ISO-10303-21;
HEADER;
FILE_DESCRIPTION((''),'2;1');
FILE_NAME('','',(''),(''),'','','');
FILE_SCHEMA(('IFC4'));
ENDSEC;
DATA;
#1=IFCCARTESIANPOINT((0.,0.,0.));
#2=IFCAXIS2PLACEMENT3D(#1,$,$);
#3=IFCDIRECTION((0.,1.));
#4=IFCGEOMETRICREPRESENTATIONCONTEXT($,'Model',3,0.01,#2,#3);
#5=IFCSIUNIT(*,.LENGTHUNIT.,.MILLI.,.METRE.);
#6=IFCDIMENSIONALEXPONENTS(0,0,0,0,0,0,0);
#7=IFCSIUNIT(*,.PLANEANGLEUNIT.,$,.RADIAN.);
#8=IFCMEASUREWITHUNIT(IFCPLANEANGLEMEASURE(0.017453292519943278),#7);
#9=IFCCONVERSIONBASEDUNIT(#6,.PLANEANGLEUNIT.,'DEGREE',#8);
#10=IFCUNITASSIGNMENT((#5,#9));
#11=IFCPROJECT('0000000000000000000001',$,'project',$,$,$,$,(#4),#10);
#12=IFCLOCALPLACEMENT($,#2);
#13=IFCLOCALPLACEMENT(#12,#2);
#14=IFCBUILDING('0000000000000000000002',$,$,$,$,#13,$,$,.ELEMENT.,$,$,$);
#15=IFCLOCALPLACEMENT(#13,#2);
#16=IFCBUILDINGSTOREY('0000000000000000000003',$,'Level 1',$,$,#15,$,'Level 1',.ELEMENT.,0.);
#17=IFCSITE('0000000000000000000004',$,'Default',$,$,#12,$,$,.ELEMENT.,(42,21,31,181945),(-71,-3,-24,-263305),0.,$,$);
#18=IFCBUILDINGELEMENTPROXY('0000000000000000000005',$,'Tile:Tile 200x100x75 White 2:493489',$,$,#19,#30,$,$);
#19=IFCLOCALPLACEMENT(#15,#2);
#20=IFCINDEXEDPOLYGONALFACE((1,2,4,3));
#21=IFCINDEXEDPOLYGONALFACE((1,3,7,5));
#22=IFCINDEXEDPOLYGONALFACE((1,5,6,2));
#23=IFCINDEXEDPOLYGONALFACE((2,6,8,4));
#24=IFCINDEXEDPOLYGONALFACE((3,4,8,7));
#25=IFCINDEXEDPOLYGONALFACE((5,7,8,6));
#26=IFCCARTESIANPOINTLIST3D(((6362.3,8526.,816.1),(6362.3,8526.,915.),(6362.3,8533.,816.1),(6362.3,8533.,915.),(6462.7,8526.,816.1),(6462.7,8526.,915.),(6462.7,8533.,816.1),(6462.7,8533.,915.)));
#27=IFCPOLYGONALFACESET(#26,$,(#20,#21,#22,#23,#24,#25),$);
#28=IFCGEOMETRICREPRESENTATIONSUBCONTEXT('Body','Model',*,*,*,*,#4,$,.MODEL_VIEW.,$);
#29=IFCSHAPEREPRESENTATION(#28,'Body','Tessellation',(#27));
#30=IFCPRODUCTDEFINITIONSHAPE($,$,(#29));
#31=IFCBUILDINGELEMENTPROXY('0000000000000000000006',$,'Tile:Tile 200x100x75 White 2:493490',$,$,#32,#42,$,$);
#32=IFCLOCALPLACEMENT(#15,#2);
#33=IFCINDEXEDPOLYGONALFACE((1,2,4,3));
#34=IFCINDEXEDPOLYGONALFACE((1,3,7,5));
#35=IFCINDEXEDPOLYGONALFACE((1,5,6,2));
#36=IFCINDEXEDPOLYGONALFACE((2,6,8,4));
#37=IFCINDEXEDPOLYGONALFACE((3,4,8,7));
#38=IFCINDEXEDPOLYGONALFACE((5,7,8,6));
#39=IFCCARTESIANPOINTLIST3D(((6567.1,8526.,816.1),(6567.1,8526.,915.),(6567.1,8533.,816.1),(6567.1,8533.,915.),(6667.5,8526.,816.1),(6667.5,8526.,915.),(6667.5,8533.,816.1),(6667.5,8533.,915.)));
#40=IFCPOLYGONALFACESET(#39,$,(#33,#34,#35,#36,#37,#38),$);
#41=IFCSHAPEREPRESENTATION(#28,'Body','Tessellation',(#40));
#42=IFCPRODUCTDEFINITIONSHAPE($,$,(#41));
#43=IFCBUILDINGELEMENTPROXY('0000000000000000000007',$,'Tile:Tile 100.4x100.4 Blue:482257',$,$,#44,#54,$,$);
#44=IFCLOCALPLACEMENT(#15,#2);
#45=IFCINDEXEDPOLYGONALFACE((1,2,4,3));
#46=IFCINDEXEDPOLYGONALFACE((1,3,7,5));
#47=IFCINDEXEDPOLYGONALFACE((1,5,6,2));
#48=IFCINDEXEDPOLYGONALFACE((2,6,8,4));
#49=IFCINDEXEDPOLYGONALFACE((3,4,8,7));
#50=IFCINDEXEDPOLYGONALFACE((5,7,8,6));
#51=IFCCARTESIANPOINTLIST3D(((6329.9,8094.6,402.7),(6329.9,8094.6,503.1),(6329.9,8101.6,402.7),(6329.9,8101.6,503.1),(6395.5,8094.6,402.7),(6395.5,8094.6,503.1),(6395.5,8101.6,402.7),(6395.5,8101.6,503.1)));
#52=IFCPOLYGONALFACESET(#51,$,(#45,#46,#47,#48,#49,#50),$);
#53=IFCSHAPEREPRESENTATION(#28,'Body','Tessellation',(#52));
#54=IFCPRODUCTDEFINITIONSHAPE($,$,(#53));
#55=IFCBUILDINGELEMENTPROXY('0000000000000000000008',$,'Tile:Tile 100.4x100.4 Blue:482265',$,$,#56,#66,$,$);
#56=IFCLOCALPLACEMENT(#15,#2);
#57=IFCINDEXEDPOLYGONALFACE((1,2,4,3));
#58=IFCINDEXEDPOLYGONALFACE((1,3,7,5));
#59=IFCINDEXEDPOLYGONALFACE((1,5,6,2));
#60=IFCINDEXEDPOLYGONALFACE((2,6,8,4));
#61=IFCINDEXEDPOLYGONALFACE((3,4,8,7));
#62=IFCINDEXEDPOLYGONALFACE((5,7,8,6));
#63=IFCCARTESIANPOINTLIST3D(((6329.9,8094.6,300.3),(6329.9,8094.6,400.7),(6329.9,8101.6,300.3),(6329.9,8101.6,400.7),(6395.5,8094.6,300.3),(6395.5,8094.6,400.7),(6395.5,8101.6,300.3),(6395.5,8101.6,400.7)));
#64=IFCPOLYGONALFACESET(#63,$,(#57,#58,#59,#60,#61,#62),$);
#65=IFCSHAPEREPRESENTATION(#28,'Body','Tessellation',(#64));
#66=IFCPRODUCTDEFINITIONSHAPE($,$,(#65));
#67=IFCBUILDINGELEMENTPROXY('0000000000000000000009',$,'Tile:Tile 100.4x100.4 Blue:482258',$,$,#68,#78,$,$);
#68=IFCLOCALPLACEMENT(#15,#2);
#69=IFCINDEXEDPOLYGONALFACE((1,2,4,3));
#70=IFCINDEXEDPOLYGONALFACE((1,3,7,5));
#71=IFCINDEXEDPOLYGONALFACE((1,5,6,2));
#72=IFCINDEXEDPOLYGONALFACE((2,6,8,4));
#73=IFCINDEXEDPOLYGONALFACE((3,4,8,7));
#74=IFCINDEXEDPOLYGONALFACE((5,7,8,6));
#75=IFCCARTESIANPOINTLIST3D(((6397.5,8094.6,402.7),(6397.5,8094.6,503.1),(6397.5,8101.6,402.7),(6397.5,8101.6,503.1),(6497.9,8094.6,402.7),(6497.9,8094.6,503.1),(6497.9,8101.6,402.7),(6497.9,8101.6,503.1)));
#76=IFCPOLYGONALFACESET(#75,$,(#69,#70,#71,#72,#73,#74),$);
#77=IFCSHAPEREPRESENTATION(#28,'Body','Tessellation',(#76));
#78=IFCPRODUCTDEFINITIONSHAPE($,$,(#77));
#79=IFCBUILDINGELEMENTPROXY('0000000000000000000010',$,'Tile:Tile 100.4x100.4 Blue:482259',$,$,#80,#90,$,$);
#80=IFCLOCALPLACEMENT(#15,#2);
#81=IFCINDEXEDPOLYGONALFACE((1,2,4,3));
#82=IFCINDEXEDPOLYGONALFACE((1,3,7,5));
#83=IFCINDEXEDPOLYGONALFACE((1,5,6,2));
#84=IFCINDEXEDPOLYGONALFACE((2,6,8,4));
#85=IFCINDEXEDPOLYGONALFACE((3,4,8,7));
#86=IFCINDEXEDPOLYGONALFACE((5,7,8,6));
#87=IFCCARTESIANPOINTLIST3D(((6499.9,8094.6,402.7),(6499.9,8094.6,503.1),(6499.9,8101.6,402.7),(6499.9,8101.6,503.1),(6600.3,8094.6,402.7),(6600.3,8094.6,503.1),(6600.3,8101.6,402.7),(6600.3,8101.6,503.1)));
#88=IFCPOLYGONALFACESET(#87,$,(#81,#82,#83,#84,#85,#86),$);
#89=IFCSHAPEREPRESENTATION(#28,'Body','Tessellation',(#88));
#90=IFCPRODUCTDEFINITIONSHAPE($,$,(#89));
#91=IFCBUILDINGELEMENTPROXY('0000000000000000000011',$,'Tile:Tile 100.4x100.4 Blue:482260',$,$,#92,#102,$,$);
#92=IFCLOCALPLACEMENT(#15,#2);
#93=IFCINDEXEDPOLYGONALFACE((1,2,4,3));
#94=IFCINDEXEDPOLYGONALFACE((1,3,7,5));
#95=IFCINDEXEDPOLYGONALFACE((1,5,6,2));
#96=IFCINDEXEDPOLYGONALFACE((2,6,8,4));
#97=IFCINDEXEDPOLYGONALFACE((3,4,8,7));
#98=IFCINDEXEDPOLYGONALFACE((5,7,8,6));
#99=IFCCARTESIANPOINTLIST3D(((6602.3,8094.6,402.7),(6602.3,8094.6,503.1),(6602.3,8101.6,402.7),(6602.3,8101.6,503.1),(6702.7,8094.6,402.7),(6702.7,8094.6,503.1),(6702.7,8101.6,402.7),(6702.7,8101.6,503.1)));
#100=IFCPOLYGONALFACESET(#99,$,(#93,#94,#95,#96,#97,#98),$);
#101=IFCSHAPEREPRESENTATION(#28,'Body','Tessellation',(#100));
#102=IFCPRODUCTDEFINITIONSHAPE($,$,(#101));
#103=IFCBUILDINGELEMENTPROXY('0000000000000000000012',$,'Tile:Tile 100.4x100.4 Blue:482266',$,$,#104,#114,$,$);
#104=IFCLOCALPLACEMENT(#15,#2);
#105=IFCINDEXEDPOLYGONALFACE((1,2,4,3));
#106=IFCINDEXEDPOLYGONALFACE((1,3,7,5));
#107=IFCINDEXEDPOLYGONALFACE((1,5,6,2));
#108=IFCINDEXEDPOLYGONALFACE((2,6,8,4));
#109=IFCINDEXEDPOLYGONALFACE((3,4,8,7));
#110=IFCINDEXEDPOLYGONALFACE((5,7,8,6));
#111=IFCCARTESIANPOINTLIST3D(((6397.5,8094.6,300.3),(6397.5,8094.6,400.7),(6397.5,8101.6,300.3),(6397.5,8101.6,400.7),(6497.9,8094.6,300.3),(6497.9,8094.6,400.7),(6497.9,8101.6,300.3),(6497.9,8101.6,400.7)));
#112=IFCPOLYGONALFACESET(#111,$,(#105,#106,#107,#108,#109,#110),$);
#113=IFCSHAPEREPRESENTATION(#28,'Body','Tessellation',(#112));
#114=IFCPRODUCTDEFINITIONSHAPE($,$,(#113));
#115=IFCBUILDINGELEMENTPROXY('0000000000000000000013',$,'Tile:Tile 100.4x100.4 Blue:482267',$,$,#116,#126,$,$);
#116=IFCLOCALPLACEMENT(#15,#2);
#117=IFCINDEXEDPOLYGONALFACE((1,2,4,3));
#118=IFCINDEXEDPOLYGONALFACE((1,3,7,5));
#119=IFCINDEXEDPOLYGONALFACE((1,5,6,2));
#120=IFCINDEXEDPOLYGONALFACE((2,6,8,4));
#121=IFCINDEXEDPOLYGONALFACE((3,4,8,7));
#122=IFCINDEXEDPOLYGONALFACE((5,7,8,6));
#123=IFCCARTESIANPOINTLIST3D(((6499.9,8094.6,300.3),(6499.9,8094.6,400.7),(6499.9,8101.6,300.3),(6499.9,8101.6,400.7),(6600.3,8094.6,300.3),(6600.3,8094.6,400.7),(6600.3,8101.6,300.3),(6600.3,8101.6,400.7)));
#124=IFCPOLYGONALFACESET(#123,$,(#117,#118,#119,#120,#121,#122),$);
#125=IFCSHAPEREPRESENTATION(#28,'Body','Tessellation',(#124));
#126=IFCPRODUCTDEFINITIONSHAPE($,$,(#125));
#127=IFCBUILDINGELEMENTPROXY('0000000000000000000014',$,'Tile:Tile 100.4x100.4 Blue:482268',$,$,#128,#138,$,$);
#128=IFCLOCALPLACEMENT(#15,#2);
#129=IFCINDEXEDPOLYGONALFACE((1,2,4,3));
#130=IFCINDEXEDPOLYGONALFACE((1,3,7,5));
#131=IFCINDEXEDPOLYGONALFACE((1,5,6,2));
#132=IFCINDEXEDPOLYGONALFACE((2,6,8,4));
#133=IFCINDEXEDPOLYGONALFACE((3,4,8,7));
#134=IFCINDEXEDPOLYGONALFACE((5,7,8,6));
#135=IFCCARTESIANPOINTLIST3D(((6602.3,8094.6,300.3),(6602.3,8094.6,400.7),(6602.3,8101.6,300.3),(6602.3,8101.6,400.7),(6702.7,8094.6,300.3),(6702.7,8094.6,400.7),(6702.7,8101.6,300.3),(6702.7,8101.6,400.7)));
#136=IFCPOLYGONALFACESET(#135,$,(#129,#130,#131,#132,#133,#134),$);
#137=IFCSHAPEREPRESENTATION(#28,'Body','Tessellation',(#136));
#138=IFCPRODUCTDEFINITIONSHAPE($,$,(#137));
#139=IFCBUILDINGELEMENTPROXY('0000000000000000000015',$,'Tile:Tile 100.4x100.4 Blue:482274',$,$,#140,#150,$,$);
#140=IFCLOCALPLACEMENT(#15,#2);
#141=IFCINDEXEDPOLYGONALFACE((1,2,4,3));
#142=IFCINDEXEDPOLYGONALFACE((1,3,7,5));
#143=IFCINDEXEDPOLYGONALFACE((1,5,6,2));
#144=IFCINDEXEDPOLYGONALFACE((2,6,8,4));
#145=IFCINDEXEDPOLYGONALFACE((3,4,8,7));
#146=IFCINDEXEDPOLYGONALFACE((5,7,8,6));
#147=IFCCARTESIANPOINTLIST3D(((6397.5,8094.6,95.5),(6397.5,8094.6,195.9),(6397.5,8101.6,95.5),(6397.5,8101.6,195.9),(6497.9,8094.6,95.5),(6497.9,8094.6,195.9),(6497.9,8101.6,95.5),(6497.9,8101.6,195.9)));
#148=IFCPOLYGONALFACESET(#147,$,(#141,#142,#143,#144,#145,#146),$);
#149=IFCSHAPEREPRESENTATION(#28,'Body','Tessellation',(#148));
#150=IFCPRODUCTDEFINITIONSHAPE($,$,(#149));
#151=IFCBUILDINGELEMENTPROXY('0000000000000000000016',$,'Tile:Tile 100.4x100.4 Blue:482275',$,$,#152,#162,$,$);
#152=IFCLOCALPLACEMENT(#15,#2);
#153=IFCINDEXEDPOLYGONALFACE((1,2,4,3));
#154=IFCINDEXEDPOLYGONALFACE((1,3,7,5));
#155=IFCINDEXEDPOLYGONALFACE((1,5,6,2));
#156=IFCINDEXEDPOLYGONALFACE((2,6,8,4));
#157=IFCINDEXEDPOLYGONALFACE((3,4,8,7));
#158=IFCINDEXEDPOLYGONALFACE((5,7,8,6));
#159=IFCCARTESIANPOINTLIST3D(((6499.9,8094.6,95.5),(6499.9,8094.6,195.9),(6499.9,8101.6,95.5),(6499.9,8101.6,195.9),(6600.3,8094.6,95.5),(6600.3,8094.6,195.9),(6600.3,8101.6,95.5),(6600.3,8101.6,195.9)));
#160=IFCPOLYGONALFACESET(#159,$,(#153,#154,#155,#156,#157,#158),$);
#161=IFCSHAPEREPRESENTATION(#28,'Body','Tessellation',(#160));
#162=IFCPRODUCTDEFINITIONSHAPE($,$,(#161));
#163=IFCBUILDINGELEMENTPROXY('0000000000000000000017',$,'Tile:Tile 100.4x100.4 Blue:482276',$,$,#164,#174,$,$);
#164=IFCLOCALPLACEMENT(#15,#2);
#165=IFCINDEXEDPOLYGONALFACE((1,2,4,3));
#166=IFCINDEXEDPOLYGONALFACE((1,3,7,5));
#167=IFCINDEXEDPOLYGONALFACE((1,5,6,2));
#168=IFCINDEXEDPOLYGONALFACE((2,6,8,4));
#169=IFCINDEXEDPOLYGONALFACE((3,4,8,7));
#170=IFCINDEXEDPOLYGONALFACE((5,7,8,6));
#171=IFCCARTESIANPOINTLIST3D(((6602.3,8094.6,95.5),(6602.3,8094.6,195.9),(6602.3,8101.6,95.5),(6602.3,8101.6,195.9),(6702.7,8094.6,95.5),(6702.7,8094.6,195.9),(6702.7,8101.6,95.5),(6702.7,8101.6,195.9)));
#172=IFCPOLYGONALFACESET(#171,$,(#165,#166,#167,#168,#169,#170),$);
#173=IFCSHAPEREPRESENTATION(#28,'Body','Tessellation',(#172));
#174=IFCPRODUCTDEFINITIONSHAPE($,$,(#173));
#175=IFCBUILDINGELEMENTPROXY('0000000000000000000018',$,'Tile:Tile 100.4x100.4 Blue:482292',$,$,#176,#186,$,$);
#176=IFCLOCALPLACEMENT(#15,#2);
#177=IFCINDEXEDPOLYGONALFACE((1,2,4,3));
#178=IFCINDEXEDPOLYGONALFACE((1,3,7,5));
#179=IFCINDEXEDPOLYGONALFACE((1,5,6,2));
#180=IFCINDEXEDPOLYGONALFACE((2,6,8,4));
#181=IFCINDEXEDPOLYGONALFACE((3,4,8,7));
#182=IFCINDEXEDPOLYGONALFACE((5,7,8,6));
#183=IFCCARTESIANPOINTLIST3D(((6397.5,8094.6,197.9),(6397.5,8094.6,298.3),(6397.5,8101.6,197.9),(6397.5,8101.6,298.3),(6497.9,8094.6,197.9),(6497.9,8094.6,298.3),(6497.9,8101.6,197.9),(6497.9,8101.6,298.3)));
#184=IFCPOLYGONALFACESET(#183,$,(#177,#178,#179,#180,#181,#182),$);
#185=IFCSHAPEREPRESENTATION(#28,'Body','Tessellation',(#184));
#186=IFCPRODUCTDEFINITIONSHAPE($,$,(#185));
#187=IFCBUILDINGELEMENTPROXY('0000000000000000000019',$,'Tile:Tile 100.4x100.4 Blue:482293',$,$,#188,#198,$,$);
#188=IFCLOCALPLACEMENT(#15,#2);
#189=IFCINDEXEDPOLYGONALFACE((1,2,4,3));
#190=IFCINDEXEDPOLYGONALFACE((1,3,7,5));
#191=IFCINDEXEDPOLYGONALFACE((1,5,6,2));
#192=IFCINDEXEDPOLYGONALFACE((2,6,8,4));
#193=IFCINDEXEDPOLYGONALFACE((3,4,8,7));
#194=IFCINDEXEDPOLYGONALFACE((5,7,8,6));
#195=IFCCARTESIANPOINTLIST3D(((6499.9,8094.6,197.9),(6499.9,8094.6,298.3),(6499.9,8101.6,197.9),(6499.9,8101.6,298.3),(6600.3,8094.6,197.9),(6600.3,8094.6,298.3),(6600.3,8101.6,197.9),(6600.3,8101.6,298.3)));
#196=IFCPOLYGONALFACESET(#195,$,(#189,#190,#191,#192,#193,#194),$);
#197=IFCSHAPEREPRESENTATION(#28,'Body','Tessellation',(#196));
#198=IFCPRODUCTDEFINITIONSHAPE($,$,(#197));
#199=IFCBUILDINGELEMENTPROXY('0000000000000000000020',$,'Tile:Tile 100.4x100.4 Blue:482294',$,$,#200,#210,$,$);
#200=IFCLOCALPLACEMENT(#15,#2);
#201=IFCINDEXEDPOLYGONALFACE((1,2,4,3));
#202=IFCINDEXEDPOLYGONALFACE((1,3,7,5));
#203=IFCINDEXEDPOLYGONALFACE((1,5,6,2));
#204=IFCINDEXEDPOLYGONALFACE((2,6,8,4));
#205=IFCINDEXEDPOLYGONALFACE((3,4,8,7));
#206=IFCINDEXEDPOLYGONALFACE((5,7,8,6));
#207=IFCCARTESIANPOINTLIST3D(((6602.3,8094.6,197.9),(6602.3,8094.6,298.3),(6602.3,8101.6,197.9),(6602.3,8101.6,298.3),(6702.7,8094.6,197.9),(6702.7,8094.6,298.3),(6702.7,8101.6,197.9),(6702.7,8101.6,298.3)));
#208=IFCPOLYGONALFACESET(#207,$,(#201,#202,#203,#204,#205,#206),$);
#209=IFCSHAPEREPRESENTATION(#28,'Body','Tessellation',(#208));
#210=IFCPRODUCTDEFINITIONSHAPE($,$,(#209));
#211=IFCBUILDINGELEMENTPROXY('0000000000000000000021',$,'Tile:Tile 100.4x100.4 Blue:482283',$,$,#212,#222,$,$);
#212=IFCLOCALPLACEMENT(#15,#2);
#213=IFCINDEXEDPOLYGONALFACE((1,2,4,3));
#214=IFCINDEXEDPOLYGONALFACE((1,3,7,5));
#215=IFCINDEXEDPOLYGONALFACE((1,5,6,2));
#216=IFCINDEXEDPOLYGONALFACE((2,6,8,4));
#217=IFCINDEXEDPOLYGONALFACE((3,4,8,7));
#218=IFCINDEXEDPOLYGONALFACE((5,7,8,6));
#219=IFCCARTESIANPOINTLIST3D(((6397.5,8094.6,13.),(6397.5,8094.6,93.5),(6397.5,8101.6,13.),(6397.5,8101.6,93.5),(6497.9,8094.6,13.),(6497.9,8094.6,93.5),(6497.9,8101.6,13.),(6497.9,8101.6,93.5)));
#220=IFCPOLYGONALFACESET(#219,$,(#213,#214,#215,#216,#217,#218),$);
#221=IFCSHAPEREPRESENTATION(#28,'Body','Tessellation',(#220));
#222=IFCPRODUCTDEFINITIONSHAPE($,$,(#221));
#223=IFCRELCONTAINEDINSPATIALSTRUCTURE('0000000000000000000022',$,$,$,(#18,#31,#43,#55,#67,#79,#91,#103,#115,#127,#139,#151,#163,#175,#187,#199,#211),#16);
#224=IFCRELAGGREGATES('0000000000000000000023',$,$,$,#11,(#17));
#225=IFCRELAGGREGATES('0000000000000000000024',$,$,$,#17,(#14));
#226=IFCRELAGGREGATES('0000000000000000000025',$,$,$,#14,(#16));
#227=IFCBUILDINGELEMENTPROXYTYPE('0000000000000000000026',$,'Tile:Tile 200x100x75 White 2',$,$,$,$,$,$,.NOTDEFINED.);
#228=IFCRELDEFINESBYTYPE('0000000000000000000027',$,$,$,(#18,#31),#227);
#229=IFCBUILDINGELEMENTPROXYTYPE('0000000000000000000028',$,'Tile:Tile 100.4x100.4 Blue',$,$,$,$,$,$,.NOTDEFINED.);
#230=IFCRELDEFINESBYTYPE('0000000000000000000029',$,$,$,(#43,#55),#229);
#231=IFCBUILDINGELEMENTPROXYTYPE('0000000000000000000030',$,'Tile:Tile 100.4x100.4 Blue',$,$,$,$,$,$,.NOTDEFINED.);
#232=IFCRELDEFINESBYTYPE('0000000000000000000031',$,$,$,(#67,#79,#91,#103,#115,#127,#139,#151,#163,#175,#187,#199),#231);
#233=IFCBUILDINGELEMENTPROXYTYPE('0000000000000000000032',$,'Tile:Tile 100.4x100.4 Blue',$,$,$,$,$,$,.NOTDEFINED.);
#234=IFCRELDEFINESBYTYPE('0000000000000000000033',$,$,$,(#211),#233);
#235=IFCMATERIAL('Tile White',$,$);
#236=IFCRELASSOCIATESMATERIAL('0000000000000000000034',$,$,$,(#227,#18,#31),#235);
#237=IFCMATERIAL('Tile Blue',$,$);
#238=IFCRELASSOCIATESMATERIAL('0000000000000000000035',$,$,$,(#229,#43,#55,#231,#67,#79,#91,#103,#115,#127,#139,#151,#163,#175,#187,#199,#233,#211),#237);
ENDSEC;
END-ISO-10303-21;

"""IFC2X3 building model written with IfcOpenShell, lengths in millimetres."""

from ifc_helpers import new_model, entity, si_unit, converted_unit, direction, frame, frame_2d, origin, origin_2d_with_axis, place, context, subcontext, project, spatial, rectangle, extrude, source, transform, mapped, material, type_object, type_shapes, element, save


model = new_model("IFC2X3")

# Units and contexts
model_context = context("Model", 3, precision=0.01, world=origin(), true_north=direction((0.0, 1.0)))
body_context = subcontext(model_context, "Body", "Model", "MODEL_VIEW")
ifc_project = project(units=[si_unit("LENGTHUNIT", "METRE", prefix="MILLI"), converted_unit("PLANEANGLEUNIT", "DEGREE", entity("IfcPlaneAngleMeasure", 0.017453292519943278), si_unit("PLANEANGLEUNIT", "RADIAN"), dimensions=[0, 0, 0, 0, 0, 0, 0])], contexts=[model_context])

# Site, building, storey
site_placement = place(None, origin())
site = spatial("IfcSite", under=ifc_project, at=site_placement, Name="Default", CompositionType="ELEMENT", RefLatitude=(42, 21, 31, 181945), RefLongitude=(-71, -3, -24, -263305), RefElevation=0.0)
building_placement = place(site_placement, origin())
building = spatial("IfcBuilding", under=site, at=building_placement, CompositionType="ELEMENT")
storey_placement = place(building_placement, origin())
storey = spatial("IfcBuildingStorey", under=building, at=storey_placement, Name="Level 1", LongName="Level 1", CompositionType="ELEMENT", Elevation=0.0)

# Building element proxies
ifc_material_1 = material(Name="Tile White")
building_element_proxy_type_1 = type_object("IfcBuildingElementProxyType", Name="Tile:Tile 200x100x75 White 2", PredefinedType="NOTDEFINED", material=ifc_material_1)
shared_shape_1 = source(origin(), body_context, "Body", "SweptSolid", [
    extrude(rectangle(XDim=98.9, YDim=100.4, at=origin_2d_with_axis()), frame((-50.2, -49.5, 0.0), z_axis=(0.0, 0.0, 1.0), x_axis=(0.0, -1.0, 0.0)), (0.0, 0.0, 1.0), 7.0),
])
type_shapes(building_element_proxy_type_1, [shared_shape_1])
for number, where, z_axis, x_axis, name in (
    (1, (6462.7, 8533.0, 915.0), (0.0, -1.0, 0.0), (1.0, 0.0, 0.0), "Tile:Tile 200x100x75 White 2:493489"),
    (2, (6667.5, 8533.0, 915.0), (0.0, -1.0, 0.0), (1.0, 0.0, 0.0), "Tile:Tile 200x100x75 White 2:493490"),
):
    element("IfcBuildingElementProxy", number, at=place(storey_placement, frame(where, z_axis=z_axis, x_axis=x_axis)), inside=storey, type_object=building_element_proxy_type_1, material=ifc_material_1, Name=name, context=body_context, shape_type="MappedRepresentation", body=[
        mapped(shared_shape_1, transform((0.0, 0.0, 0.0), scale=1.0)),
    ])
ifc_material_2 = material(Name="Tile Blue")
building_element_proxy_type_2 = type_object("IfcBuildingElementProxyType", Name="Tile:Tile 100.4x100.4 Blue", PredefinedType="NOTDEFINED", material=ifc_material_2)
shared_shape_2 = source(origin(), body_context, "Body", "SweptSolid", [
    extrude(rectangle(XDim=65.6, YDim=100.4, at=frame_2d((0.0, 0.0), x_axis=(1.0, 0.0))), frame((-32.8, -50.2, 0.0), z_axis=(0.0, 0.0, 1.0), x_axis=(-1.0, 0.0, 0.0)), (0.0, 0.0, 1.0), 7.0),
])
type_shapes(building_element_proxy_type_2, [shared_shape_2])
for number, where, z_axis, x_axis, name in (
    (3, (6329.9, 8101.6, 402.7), (0.0, -1.0, 0.0), (-1.0, 0.0, 0.0), "Tile:Tile 100.4x100.4 Blue:482257"),
    (4, (6329.9, 8101.6, 300.3), (0.0, -1.0, 0.0), (-1.0, 0.0, 0.0), "Tile:Tile 100.4x100.4 Blue:482265"),
):
    element("IfcBuildingElementProxy", number, at=place(storey_placement, frame(where, z_axis=z_axis, x_axis=x_axis)), inside=storey, type_object=building_element_proxy_type_2, material=ifc_material_2, Name=name, context=body_context, shape_type="MappedRepresentation", body=[
        mapped(shared_shape_2, transform((0.0, 0.0, 0.0), scale=1.0)),
    ])
building_element_proxy_type_3 = type_object("IfcBuildingElementProxyType", Name="Tile:Tile 100.4x100.4 Blue", PredefinedType="NOTDEFINED", material=ifc_material_2)
shared_shape_3 = source(origin(), body_context, "Body", "SweptSolid", [
    extrude(rectangle(XDim=100.4, YDim=100.4, at=origin_2d_with_axis()), frame((-50.2, -50.2, 0.0), z_axis=(0.0, 0.0, 1.0), x_axis=(0.0, -1.0, 0.0)), (0.0, 0.0, 1.0), 7.0),
])
type_shapes(building_element_proxy_type_3, [shared_shape_3])
for number, where, z_axis, x_axis, name in (
    (5, (6397.5, 8101.6, 402.7), (0.0, -1.0, 0.0), (-1.0, 0.0, 0.0), "Tile:Tile 100.4x100.4 Blue:482258"),
    (6, (6499.9, 8101.6, 402.7), (0.0, -1.0, 0.0), (-1.0, 0.0, 0.0), "Tile:Tile 100.4x100.4 Blue:482259"),
    (7, (6602.3, 8101.6, 402.7), (0.0, -1.0, 0.0), (-1.0, 0.0, 0.0), "Tile:Tile 100.4x100.4 Blue:482260"),
    (8, (6397.5, 8101.6, 300.3), (0.0, -1.0, 0.0), (-1.0, 0.0, 0.0), "Tile:Tile 100.4x100.4 Blue:482266"),
    (9, (6499.9, 8101.6, 300.3), (0.0, -1.0, 0.0), (-1.0, 0.0, 0.0), "Tile:Tile 100.4x100.4 Blue:482267"),
    (10, (6602.3, 8101.6, 300.3), (0.0, -1.0, 0.0), (-1.0, 0.0, 0.0), "Tile:Tile 100.4x100.4 Blue:482268"),
    (11, (6397.5, 8101.6, 95.5), (0.0, -1.0, 0.0), (-1.0, 0.0, 0.0), "Tile:Tile 100.4x100.4 Blue:482274"),
    (12, (6499.9, 8101.6, 95.5), (0.0, -1.0, 0.0), (-1.0, 0.0, 0.0), "Tile:Tile 100.4x100.4 Blue:482275"),
    (13, (6602.3, 8101.6, 95.5), (0.0, -1.0, 0.0), (-1.0, 0.0, 0.0), "Tile:Tile 100.4x100.4 Blue:482276"),
    (14, (6397.5, 8101.6, 197.9), (0.0, -1.0, 0.0), (-1.0, 0.0, 0.0), "Tile:Tile 100.4x100.4 Blue:482292"),
    (15, (6499.9, 8101.6, 197.9), (0.0, -1.0, 0.0), (-1.0, 0.0, 0.0), "Tile:Tile 100.4x100.4 Blue:482293"),
    (16, (6602.3, 8101.6, 197.9), (0.0, -1.0, 0.0), (-1.0, 0.0, 0.0), "Tile:Tile 100.4x100.4 Blue:482294"),
):
    element("IfcBuildingElementProxy", number, at=place(storey_placement, frame(where, z_axis=z_axis, x_axis=x_axis)), inside=storey, type_object=building_element_proxy_type_3, material=ifc_material_2, Name=name, context=body_context, shape_type="MappedRepresentation", body=[
        mapped(shared_shape_3, transform((0.0, 0.0, 0.0), scale=1.0)),
    ])
building_element_proxy_type_4 = type_object("IfcBuildingElementProxyType", Name="Tile:Tile 100.4x100.4 Blue", PredefinedType="NOTDEFINED", material=ifc_material_2)
shared_shape_4 = source(origin(), body_context, "Body", "SweptSolid", [
    extrude(rectangle(XDim=80.5, YDim=100.4, at=origin_2d_with_axis()), frame((-50.2, -40.3, 0.0), z_axis=(0.0, 0.0, 1.0), x_axis=(0.0, -1.0, 0.0)), (0.0, 0.0, 1.0), 7.0),
])
type_shapes(building_element_proxy_type_4, [shared_shape_4])
for number, where, z_axis, x_axis, name in (
    (17, (6397.5, 8101.6, 13.0), (0.0, -1.0, 0.0), (-1.0, 0.0, 0.0), "Tile:Tile 100.4x100.4 Blue:482283"),
):
    element("IfcBuildingElementProxy", number, at=place(storey_placement, frame(where, z_axis=z_axis, x_axis=x_axis)), inside=storey, type_object=building_element_proxy_type_4, material=ifc_material_2, Name=name, context=body_context, shape_type="MappedRepresentation", body=[
        mapped(shared_shape_4, transform((0.0, 0.0, 0.0), scale=1.0)),
    ])

save(model, "model.ifc")
